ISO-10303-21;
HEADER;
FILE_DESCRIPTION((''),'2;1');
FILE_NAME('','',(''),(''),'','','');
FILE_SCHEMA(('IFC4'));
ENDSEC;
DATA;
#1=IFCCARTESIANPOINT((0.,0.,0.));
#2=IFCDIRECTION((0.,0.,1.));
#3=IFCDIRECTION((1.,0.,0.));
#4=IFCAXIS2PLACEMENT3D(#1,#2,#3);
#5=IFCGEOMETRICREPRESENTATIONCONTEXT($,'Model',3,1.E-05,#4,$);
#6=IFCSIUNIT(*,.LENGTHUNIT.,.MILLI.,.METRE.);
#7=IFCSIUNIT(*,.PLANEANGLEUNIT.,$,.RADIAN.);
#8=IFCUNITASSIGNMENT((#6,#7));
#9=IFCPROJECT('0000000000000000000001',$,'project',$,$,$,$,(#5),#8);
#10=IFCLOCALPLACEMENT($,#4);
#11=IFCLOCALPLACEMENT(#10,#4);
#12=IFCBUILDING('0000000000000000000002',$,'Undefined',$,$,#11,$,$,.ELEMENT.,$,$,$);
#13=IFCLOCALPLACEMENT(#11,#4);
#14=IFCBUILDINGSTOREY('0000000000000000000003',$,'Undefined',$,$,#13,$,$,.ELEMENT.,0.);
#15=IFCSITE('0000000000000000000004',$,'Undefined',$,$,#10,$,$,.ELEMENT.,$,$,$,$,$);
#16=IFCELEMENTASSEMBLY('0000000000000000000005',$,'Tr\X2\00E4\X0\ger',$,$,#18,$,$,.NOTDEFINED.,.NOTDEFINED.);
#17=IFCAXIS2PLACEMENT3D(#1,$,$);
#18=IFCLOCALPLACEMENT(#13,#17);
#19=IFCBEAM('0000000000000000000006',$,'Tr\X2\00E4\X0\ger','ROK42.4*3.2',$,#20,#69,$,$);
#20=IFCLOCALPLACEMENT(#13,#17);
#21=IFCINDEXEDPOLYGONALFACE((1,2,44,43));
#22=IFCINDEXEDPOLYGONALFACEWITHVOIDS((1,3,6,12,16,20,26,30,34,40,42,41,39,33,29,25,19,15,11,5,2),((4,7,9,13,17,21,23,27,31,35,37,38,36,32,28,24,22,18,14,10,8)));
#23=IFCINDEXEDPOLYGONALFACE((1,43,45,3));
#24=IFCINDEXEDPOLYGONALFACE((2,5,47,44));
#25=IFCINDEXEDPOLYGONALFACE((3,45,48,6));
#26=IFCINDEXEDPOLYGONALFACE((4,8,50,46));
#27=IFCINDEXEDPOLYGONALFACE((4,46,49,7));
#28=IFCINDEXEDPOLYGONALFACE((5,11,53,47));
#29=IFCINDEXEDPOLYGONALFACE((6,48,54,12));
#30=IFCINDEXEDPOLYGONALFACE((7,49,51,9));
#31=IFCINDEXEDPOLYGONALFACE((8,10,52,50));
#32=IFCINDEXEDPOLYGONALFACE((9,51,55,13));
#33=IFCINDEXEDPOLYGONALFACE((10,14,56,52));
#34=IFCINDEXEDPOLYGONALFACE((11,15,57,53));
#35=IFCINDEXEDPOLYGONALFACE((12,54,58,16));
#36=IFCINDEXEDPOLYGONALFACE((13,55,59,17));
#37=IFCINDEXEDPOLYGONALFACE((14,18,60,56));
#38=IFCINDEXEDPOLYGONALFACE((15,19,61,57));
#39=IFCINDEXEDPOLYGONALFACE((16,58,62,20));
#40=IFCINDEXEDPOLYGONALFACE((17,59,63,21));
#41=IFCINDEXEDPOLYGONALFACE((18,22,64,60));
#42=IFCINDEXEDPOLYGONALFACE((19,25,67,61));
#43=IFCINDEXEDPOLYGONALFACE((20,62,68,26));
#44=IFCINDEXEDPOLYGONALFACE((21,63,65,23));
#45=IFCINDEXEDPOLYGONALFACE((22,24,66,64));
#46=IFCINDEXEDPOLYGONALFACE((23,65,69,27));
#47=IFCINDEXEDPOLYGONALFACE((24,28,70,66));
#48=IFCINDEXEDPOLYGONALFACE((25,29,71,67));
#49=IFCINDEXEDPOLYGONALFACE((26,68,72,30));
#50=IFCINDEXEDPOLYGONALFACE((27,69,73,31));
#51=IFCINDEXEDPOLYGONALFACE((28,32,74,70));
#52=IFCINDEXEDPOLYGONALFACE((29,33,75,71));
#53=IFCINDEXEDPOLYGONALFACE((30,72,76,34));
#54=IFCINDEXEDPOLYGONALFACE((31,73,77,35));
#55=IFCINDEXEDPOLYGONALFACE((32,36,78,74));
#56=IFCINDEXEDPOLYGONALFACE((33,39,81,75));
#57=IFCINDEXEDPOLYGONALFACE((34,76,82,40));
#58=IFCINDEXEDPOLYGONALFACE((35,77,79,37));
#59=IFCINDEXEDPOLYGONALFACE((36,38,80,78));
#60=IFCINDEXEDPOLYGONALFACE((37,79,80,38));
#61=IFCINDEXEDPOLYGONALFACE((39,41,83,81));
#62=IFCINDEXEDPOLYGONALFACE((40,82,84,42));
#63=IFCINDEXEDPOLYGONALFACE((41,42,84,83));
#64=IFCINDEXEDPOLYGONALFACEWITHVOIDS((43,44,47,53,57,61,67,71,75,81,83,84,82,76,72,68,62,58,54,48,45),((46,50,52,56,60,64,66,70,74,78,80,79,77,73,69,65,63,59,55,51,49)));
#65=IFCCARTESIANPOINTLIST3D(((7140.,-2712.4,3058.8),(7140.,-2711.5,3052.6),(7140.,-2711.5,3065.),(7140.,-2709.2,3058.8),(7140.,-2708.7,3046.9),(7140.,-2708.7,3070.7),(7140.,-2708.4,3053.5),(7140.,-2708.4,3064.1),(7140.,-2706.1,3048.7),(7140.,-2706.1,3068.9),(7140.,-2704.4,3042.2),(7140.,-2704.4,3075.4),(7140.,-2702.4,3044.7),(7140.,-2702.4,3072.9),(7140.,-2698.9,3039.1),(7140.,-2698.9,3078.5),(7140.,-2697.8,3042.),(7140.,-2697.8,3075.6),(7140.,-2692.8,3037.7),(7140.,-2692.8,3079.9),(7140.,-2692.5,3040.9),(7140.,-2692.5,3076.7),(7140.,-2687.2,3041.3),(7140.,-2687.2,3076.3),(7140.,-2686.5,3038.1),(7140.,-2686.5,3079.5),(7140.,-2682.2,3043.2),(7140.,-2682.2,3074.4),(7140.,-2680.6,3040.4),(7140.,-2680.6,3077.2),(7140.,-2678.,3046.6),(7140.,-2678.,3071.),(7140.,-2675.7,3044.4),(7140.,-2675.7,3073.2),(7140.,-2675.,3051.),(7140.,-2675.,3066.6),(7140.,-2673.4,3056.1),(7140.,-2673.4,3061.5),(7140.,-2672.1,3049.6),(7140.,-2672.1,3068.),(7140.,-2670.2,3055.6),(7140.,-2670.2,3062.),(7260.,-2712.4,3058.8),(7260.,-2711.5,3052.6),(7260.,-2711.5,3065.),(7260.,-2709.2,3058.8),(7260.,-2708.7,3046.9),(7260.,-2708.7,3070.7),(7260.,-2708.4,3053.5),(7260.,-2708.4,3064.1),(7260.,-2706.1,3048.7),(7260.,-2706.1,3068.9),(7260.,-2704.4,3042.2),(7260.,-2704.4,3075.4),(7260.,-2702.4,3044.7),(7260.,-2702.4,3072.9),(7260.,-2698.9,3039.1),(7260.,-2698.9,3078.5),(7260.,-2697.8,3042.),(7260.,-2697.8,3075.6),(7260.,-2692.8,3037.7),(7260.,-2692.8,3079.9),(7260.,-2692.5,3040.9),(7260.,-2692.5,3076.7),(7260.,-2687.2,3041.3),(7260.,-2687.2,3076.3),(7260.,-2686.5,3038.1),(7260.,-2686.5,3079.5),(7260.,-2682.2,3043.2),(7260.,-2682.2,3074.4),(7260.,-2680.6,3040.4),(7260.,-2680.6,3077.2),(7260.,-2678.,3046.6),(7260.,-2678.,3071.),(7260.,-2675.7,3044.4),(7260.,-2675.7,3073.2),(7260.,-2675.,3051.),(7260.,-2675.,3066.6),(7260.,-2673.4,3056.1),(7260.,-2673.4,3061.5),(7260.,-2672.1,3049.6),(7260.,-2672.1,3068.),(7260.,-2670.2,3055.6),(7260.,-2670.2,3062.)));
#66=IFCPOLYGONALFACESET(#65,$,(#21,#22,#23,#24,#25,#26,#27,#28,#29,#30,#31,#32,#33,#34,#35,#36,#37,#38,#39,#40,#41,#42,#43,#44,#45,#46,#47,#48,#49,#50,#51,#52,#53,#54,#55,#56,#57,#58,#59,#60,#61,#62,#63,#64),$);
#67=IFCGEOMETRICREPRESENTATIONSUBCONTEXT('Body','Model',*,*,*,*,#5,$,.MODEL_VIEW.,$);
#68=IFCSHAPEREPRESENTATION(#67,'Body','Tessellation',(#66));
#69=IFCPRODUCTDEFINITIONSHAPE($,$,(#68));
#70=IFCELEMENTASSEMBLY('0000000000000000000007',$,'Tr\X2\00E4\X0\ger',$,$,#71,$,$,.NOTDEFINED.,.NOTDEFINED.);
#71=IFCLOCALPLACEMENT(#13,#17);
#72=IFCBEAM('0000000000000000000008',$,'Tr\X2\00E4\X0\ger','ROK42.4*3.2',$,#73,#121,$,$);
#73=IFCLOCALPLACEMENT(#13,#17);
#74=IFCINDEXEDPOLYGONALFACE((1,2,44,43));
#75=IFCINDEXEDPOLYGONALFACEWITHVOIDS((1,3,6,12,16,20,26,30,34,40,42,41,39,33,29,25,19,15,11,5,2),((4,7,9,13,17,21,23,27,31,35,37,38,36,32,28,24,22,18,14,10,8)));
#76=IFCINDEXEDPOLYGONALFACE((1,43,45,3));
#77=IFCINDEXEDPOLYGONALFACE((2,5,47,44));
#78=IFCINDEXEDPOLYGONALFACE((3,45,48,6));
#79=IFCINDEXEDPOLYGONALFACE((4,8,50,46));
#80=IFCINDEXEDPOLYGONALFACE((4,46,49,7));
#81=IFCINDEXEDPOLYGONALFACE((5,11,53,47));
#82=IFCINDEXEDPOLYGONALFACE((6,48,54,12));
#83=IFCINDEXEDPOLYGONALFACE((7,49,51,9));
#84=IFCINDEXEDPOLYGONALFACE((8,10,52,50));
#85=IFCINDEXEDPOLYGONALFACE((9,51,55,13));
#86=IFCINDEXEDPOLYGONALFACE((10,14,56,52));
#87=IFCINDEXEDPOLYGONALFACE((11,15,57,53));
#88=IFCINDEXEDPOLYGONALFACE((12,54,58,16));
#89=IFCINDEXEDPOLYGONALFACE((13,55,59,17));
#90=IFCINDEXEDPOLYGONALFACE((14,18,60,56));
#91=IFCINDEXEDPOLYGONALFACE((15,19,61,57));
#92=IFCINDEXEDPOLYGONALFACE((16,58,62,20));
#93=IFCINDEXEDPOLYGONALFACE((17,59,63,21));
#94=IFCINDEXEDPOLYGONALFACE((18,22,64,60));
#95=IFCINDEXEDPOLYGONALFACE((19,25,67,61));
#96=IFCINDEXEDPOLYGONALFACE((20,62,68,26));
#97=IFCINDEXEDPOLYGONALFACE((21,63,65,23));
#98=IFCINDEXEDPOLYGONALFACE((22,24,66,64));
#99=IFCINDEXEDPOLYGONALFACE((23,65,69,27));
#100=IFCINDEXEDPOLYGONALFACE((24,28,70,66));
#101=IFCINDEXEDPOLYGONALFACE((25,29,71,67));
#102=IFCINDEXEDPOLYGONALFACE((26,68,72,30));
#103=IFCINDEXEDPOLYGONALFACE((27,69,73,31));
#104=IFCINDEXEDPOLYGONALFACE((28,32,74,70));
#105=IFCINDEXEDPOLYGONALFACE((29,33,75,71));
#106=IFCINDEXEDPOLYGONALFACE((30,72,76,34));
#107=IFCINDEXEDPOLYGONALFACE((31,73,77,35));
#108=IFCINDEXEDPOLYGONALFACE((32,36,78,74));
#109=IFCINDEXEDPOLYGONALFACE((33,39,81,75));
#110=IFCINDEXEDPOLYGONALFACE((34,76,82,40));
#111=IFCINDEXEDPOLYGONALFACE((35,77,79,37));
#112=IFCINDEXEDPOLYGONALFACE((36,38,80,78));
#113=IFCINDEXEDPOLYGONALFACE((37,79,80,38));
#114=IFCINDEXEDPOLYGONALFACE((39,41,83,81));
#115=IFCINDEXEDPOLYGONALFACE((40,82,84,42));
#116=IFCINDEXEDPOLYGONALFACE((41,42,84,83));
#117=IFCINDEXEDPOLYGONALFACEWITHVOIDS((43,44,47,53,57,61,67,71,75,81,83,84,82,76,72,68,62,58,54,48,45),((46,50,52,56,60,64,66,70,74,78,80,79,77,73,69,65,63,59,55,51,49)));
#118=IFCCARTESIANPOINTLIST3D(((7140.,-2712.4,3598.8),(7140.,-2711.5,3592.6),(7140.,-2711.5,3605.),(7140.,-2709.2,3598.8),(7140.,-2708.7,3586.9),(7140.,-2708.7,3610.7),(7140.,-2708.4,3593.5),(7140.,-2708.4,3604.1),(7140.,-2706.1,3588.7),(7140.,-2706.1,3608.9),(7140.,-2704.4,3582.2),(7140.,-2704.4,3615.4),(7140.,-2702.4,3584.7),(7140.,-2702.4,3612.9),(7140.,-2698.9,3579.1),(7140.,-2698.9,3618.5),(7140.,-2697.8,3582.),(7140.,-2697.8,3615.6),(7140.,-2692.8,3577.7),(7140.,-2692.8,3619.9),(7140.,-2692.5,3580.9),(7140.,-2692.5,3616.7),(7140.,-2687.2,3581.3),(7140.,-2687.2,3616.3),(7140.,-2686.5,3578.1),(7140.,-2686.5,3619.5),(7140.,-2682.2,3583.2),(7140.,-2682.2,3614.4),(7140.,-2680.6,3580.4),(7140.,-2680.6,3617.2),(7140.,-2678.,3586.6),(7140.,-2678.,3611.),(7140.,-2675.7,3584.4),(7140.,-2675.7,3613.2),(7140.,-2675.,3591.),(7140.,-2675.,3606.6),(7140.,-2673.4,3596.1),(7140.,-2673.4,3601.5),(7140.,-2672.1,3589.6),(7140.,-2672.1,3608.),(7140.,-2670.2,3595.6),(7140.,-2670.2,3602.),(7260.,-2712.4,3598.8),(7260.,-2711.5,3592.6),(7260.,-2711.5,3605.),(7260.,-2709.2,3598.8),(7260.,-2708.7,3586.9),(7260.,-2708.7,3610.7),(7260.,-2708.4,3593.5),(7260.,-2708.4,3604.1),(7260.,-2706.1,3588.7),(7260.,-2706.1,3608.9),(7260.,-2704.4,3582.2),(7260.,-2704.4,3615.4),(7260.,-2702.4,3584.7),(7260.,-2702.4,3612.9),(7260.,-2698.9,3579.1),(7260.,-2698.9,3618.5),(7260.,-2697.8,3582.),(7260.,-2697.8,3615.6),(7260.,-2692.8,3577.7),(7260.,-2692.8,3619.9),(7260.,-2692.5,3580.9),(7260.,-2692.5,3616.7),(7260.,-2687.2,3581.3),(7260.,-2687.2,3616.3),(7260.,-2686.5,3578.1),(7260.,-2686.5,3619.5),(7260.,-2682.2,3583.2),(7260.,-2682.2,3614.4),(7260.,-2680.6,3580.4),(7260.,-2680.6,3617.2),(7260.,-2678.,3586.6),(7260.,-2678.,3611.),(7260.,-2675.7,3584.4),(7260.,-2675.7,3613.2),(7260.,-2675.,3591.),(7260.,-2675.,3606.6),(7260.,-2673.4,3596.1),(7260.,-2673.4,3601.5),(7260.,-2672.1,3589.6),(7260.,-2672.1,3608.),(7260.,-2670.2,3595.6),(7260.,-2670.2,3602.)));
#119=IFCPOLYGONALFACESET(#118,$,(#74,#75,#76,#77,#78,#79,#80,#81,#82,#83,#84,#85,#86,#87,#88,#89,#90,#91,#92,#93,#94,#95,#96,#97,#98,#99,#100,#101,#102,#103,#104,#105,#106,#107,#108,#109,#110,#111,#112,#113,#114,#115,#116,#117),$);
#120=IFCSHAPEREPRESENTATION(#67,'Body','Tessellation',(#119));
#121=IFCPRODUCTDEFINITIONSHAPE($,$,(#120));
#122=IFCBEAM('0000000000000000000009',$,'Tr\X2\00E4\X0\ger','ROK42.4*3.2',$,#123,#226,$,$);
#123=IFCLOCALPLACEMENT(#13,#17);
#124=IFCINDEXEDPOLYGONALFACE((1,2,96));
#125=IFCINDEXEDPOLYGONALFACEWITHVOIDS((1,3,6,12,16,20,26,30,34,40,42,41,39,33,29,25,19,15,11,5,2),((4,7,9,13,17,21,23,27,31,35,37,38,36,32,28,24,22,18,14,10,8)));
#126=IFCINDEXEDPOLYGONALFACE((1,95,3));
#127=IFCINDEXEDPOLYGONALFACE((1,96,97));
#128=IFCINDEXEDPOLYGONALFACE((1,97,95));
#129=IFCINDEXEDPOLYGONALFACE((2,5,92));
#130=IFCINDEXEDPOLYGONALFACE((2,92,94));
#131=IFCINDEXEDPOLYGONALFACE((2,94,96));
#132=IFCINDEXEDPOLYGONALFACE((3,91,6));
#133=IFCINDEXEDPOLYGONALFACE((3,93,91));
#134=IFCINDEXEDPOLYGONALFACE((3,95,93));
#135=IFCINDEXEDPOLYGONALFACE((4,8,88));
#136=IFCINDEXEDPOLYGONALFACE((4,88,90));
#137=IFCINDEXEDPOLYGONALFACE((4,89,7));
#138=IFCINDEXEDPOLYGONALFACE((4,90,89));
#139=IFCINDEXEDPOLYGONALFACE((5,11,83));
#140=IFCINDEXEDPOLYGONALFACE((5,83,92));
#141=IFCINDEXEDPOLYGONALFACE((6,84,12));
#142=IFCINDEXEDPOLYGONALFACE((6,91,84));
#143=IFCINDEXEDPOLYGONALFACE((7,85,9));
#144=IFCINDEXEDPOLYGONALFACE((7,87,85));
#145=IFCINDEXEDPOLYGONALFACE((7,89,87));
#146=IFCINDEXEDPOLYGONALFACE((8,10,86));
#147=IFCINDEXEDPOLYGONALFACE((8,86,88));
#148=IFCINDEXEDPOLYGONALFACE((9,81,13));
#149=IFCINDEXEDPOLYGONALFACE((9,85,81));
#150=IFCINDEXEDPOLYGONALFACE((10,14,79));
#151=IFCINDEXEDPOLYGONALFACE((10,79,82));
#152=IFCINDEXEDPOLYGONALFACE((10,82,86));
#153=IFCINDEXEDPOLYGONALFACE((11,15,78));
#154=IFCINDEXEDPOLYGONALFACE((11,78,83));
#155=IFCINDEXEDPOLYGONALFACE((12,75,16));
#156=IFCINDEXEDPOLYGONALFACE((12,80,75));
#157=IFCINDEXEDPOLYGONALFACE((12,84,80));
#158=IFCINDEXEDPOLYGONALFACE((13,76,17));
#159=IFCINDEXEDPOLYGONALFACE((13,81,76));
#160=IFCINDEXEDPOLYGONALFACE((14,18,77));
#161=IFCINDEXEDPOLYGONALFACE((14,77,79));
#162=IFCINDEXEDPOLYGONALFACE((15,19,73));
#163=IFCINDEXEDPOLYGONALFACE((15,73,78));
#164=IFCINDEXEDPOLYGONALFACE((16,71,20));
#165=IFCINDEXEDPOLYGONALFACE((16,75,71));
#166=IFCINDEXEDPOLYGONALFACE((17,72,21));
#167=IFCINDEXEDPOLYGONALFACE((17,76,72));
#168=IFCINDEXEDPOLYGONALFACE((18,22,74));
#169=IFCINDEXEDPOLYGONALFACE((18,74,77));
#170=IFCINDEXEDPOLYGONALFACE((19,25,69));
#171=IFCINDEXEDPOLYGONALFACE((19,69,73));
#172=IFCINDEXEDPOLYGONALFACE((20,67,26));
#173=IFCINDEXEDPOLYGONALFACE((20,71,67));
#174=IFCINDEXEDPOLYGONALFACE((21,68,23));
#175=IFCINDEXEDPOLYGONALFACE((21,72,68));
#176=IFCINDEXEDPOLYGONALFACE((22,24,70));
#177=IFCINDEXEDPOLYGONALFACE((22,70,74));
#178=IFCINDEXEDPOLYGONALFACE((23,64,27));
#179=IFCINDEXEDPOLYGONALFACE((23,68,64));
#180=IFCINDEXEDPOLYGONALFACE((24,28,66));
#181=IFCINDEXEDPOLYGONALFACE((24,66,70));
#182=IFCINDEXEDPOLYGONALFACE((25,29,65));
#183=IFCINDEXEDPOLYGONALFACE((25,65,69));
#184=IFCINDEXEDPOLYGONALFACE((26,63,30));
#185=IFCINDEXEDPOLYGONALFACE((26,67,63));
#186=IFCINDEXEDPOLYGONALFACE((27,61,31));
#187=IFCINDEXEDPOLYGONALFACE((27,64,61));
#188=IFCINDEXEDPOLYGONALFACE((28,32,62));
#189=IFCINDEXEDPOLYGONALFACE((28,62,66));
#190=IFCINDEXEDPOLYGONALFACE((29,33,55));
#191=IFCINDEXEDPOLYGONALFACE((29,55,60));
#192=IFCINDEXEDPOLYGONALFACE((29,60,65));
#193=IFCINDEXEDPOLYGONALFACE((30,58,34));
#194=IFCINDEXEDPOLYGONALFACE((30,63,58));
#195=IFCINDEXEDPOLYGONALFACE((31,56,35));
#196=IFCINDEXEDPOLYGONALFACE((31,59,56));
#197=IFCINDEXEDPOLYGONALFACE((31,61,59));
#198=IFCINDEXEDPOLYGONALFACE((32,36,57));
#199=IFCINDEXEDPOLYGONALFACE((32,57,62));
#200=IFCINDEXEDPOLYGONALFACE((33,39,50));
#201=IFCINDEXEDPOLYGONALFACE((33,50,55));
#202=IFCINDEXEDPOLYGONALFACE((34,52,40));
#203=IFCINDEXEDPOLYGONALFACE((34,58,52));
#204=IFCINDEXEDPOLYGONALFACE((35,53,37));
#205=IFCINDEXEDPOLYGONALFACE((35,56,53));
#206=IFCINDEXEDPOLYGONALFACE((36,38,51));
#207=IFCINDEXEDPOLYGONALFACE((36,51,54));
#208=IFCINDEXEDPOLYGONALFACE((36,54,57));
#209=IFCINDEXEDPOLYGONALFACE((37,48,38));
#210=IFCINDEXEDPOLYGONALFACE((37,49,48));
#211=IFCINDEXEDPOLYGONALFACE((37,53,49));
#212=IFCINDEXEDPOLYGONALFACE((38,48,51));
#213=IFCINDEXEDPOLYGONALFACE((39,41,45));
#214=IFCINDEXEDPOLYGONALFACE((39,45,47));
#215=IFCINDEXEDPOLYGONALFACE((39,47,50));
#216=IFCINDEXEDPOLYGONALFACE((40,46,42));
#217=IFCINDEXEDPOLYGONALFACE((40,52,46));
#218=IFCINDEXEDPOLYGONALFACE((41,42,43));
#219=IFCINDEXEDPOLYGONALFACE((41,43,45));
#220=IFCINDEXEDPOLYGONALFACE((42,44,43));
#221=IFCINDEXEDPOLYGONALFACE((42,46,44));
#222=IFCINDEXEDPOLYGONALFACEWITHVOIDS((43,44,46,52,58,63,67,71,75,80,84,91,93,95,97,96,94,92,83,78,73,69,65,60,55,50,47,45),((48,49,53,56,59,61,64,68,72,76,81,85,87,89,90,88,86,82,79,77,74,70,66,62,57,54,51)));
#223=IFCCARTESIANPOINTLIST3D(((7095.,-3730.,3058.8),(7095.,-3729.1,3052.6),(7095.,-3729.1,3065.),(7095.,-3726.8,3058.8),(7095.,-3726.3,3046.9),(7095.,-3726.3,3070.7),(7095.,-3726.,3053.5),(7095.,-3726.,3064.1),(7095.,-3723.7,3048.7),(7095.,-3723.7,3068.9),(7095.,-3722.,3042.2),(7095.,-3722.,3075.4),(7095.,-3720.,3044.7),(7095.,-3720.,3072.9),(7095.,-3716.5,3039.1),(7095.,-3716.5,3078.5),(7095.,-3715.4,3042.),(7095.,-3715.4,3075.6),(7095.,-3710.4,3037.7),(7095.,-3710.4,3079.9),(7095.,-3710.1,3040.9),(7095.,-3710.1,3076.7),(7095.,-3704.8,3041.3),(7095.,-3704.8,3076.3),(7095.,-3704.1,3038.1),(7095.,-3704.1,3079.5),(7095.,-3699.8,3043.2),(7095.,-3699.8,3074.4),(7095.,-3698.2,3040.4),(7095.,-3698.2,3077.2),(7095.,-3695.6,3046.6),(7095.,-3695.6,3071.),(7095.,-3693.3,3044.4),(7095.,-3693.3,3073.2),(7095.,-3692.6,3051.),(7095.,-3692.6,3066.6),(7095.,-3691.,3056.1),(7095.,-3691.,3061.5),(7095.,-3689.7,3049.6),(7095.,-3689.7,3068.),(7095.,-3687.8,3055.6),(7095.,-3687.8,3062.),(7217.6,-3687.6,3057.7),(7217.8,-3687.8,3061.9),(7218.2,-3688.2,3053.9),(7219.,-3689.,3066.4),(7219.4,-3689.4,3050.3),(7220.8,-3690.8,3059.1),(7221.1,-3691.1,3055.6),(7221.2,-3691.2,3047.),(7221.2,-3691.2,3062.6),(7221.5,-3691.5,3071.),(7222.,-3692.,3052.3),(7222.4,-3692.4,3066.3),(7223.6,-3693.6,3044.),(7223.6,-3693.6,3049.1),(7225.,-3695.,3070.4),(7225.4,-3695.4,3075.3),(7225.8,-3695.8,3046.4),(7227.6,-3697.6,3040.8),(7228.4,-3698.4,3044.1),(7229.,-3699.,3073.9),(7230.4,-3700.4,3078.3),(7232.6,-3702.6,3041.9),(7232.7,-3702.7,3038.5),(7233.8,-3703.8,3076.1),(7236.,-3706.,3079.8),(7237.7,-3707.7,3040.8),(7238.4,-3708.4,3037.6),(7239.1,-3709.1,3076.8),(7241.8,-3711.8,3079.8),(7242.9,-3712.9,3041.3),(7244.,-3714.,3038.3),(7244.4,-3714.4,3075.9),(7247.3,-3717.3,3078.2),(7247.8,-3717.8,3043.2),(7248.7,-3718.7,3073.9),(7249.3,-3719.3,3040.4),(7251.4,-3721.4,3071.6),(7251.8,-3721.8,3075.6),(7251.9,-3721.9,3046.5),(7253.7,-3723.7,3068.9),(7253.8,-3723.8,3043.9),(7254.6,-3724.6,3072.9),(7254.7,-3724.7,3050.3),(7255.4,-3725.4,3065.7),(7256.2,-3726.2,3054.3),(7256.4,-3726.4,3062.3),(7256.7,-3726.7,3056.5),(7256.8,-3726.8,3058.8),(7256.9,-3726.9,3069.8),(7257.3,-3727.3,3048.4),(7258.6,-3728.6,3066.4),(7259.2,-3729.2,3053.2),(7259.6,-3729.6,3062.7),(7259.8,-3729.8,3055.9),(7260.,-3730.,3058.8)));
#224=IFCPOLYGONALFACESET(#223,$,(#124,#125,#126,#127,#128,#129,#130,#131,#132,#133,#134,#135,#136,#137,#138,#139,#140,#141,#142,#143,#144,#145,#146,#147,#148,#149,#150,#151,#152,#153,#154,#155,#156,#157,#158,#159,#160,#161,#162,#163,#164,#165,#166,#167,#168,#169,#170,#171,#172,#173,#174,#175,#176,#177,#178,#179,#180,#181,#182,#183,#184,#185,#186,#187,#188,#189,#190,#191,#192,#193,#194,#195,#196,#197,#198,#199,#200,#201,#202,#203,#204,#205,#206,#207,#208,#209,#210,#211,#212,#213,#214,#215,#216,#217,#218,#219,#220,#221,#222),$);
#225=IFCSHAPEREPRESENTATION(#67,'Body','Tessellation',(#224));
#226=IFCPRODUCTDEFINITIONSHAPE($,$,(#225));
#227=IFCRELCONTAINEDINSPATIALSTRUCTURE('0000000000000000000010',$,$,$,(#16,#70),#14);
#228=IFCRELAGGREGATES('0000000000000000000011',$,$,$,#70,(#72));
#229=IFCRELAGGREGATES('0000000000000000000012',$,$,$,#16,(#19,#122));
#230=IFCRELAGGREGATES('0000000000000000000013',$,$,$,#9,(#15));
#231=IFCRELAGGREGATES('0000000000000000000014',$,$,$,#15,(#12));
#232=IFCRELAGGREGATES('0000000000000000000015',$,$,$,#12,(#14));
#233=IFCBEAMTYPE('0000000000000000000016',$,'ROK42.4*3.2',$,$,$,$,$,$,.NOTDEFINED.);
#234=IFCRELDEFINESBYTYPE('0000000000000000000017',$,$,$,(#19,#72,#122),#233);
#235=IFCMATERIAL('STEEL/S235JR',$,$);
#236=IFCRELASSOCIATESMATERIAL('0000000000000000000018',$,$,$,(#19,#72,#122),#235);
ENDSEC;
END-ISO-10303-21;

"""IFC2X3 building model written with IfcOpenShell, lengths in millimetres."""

from ifc_helpers import new_model, si_unit, frame, origin_with_axes, origin_2d_with_axis, place, context, subcontext, project, spatial, hollow_circle, extrude, clip, halfspace, material, type_object, element, aggregate, save


model = new_model("IFC2X3")

# Units and contexts
model_context = context("Model", 3, precision=1e-05, world=origin_with_axes())
body_context = subcontext(model_context, "Body", "Model", "MODEL_VIEW")
ifc_project = project(units=[si_unit("LENGTHUNIT", "METRE", prefix="MILLI"), si_unit("PLANEANGLEUNIT", "RADIAN")], contexts=[model_context])

# Site, building, storey
site_placement = place(None, origin_with_axes())
site = spatial("IfcSite", under=ifc_project, at=site_placement, Name="Undefined", CompositionType="ELEMENT")
building_placement = place(site_placement, origin_with_axes())
building = spatial("IfcBuilding", under=site, at=building_placement, Name="Undefined", CompositionType="ELEMENT")
storey_placement = place(building_placement, origin_with_axes())
storey = spatial("IfcBuildingStorey", under=building, at=storey_placement, Name="Undefined", CompositionType="ELEMENT", Elevation=0.0)

# Element assemblies, beams
assembly_1_placement = place(storey_placement, origin_with_axes())
assembly_1 = element("IfcElementAssembly", 1, at=assembly_1_placement, inside=storey, Name="Träger", AssemblyPlace="NOTDEFINED", PredefinedType="NOTDEFINED")
ifc_material_1 = material(Name="STEEL/S235JR")
beam_type_1 = type_object("IfcBeamType", Name="ROK42.4*3.2", PredefinedType="NOTDEFINED")
beam_1_placement = place(assembly_1_placement, frame((7140.0, -2691.2, 3058.8), z_axis=(0.0, 0.0, 1.0), x_axis=(1.0, 0.0, 0.0)))
beam_1 = element("IfcBeam", 2, at=beam_1_placement, type_object=beam_type_1, material=ifc_material_1, Name="Träger", Description="ROK42.4*3.2", context=body_context, shape_type="SweptSolid", body=[
    extrude(hollow_circle(Radius=21.2, WallThickness=3.2, at=origin_2d_with_axis()), frame((120.0, 0.0, 0.0), z_axis=(-1.0, 0.0, 0.0), x_axis=(0.0, -1.0, 0.0)), (0.0, 0.0, 1.0), 120.0),
])
assembly_2_placement = place(storey_placement, origin_with_axes())
assembly_2 = element("IfcElementAssembly", 3, at=assembly_2_placement, inside=storey, Name="Träger", AssemblyPlace="NOTDEFINED", PredefinedType="NOTDEFINED")
beam_2_placement = place(assembly_2_placement, frame((7140.0, -2691.2, 3598.8), z_axis=(0.0, 0.0, 1.0), x_axis=(1.0, 0.0, 0.0)))
beam_2 = element("IfcBeam", 4, at=beam_2_placement, type_object=beam_type_1, material=ifc_material_1, Name="Träger", Description="ROK42.4*3.2", context=body_context, shape_type="SweptSolid", body=[
    extrude(hollow_circle(Radius=21.2, WallThickness=3.2, at=origin_2d_with_axis()), frame((120.0, 0.0, 0.0), z_axis=(-1.0, 0.0, 0.0), x_axis=(0.0, -1.0, 0.0)), (0.0, 0.0, 1.0), 120.0),
])

# Beam
beam_3_placement = place(assembly_1_placement, frame((7095.0, -3708.8, 3058.8), z_axis=(0.0, 0.0, 1.0), x_axis=(1.0, 0.0, 0.0)))
beam_3 = element("IfcBeam", 5, at=beam_3_placement, type_object=beam_type_1, material=ifc_material_1, Name="Träger", Description="ROK42.4*3.2", context=body_context, shape_type="Clipping", body=[
    clip(extrude(hollow_circle(Radius=21.2, WallThickness=3.2, at=origin_2d_with_axis()), frame((165.2, 0.0, 0.0), z_axis=(-1.0, 0.0, 0.0), x_axis=(0.0, -1.0, 0.0)), (0.0, 0.0, 1.0), 165.2), halfspace(frame((122.6, 21.2, 0.0), z_axis=(-0.707107, -0.707107, 0.0), x_axis=(0.0, 0.0, 1.0)), True)),
])

aggregate(assembly_2, [beam_2])
aggregate(assembly_1, [beam_1, beam_3])

save(model, "model.ifc")
